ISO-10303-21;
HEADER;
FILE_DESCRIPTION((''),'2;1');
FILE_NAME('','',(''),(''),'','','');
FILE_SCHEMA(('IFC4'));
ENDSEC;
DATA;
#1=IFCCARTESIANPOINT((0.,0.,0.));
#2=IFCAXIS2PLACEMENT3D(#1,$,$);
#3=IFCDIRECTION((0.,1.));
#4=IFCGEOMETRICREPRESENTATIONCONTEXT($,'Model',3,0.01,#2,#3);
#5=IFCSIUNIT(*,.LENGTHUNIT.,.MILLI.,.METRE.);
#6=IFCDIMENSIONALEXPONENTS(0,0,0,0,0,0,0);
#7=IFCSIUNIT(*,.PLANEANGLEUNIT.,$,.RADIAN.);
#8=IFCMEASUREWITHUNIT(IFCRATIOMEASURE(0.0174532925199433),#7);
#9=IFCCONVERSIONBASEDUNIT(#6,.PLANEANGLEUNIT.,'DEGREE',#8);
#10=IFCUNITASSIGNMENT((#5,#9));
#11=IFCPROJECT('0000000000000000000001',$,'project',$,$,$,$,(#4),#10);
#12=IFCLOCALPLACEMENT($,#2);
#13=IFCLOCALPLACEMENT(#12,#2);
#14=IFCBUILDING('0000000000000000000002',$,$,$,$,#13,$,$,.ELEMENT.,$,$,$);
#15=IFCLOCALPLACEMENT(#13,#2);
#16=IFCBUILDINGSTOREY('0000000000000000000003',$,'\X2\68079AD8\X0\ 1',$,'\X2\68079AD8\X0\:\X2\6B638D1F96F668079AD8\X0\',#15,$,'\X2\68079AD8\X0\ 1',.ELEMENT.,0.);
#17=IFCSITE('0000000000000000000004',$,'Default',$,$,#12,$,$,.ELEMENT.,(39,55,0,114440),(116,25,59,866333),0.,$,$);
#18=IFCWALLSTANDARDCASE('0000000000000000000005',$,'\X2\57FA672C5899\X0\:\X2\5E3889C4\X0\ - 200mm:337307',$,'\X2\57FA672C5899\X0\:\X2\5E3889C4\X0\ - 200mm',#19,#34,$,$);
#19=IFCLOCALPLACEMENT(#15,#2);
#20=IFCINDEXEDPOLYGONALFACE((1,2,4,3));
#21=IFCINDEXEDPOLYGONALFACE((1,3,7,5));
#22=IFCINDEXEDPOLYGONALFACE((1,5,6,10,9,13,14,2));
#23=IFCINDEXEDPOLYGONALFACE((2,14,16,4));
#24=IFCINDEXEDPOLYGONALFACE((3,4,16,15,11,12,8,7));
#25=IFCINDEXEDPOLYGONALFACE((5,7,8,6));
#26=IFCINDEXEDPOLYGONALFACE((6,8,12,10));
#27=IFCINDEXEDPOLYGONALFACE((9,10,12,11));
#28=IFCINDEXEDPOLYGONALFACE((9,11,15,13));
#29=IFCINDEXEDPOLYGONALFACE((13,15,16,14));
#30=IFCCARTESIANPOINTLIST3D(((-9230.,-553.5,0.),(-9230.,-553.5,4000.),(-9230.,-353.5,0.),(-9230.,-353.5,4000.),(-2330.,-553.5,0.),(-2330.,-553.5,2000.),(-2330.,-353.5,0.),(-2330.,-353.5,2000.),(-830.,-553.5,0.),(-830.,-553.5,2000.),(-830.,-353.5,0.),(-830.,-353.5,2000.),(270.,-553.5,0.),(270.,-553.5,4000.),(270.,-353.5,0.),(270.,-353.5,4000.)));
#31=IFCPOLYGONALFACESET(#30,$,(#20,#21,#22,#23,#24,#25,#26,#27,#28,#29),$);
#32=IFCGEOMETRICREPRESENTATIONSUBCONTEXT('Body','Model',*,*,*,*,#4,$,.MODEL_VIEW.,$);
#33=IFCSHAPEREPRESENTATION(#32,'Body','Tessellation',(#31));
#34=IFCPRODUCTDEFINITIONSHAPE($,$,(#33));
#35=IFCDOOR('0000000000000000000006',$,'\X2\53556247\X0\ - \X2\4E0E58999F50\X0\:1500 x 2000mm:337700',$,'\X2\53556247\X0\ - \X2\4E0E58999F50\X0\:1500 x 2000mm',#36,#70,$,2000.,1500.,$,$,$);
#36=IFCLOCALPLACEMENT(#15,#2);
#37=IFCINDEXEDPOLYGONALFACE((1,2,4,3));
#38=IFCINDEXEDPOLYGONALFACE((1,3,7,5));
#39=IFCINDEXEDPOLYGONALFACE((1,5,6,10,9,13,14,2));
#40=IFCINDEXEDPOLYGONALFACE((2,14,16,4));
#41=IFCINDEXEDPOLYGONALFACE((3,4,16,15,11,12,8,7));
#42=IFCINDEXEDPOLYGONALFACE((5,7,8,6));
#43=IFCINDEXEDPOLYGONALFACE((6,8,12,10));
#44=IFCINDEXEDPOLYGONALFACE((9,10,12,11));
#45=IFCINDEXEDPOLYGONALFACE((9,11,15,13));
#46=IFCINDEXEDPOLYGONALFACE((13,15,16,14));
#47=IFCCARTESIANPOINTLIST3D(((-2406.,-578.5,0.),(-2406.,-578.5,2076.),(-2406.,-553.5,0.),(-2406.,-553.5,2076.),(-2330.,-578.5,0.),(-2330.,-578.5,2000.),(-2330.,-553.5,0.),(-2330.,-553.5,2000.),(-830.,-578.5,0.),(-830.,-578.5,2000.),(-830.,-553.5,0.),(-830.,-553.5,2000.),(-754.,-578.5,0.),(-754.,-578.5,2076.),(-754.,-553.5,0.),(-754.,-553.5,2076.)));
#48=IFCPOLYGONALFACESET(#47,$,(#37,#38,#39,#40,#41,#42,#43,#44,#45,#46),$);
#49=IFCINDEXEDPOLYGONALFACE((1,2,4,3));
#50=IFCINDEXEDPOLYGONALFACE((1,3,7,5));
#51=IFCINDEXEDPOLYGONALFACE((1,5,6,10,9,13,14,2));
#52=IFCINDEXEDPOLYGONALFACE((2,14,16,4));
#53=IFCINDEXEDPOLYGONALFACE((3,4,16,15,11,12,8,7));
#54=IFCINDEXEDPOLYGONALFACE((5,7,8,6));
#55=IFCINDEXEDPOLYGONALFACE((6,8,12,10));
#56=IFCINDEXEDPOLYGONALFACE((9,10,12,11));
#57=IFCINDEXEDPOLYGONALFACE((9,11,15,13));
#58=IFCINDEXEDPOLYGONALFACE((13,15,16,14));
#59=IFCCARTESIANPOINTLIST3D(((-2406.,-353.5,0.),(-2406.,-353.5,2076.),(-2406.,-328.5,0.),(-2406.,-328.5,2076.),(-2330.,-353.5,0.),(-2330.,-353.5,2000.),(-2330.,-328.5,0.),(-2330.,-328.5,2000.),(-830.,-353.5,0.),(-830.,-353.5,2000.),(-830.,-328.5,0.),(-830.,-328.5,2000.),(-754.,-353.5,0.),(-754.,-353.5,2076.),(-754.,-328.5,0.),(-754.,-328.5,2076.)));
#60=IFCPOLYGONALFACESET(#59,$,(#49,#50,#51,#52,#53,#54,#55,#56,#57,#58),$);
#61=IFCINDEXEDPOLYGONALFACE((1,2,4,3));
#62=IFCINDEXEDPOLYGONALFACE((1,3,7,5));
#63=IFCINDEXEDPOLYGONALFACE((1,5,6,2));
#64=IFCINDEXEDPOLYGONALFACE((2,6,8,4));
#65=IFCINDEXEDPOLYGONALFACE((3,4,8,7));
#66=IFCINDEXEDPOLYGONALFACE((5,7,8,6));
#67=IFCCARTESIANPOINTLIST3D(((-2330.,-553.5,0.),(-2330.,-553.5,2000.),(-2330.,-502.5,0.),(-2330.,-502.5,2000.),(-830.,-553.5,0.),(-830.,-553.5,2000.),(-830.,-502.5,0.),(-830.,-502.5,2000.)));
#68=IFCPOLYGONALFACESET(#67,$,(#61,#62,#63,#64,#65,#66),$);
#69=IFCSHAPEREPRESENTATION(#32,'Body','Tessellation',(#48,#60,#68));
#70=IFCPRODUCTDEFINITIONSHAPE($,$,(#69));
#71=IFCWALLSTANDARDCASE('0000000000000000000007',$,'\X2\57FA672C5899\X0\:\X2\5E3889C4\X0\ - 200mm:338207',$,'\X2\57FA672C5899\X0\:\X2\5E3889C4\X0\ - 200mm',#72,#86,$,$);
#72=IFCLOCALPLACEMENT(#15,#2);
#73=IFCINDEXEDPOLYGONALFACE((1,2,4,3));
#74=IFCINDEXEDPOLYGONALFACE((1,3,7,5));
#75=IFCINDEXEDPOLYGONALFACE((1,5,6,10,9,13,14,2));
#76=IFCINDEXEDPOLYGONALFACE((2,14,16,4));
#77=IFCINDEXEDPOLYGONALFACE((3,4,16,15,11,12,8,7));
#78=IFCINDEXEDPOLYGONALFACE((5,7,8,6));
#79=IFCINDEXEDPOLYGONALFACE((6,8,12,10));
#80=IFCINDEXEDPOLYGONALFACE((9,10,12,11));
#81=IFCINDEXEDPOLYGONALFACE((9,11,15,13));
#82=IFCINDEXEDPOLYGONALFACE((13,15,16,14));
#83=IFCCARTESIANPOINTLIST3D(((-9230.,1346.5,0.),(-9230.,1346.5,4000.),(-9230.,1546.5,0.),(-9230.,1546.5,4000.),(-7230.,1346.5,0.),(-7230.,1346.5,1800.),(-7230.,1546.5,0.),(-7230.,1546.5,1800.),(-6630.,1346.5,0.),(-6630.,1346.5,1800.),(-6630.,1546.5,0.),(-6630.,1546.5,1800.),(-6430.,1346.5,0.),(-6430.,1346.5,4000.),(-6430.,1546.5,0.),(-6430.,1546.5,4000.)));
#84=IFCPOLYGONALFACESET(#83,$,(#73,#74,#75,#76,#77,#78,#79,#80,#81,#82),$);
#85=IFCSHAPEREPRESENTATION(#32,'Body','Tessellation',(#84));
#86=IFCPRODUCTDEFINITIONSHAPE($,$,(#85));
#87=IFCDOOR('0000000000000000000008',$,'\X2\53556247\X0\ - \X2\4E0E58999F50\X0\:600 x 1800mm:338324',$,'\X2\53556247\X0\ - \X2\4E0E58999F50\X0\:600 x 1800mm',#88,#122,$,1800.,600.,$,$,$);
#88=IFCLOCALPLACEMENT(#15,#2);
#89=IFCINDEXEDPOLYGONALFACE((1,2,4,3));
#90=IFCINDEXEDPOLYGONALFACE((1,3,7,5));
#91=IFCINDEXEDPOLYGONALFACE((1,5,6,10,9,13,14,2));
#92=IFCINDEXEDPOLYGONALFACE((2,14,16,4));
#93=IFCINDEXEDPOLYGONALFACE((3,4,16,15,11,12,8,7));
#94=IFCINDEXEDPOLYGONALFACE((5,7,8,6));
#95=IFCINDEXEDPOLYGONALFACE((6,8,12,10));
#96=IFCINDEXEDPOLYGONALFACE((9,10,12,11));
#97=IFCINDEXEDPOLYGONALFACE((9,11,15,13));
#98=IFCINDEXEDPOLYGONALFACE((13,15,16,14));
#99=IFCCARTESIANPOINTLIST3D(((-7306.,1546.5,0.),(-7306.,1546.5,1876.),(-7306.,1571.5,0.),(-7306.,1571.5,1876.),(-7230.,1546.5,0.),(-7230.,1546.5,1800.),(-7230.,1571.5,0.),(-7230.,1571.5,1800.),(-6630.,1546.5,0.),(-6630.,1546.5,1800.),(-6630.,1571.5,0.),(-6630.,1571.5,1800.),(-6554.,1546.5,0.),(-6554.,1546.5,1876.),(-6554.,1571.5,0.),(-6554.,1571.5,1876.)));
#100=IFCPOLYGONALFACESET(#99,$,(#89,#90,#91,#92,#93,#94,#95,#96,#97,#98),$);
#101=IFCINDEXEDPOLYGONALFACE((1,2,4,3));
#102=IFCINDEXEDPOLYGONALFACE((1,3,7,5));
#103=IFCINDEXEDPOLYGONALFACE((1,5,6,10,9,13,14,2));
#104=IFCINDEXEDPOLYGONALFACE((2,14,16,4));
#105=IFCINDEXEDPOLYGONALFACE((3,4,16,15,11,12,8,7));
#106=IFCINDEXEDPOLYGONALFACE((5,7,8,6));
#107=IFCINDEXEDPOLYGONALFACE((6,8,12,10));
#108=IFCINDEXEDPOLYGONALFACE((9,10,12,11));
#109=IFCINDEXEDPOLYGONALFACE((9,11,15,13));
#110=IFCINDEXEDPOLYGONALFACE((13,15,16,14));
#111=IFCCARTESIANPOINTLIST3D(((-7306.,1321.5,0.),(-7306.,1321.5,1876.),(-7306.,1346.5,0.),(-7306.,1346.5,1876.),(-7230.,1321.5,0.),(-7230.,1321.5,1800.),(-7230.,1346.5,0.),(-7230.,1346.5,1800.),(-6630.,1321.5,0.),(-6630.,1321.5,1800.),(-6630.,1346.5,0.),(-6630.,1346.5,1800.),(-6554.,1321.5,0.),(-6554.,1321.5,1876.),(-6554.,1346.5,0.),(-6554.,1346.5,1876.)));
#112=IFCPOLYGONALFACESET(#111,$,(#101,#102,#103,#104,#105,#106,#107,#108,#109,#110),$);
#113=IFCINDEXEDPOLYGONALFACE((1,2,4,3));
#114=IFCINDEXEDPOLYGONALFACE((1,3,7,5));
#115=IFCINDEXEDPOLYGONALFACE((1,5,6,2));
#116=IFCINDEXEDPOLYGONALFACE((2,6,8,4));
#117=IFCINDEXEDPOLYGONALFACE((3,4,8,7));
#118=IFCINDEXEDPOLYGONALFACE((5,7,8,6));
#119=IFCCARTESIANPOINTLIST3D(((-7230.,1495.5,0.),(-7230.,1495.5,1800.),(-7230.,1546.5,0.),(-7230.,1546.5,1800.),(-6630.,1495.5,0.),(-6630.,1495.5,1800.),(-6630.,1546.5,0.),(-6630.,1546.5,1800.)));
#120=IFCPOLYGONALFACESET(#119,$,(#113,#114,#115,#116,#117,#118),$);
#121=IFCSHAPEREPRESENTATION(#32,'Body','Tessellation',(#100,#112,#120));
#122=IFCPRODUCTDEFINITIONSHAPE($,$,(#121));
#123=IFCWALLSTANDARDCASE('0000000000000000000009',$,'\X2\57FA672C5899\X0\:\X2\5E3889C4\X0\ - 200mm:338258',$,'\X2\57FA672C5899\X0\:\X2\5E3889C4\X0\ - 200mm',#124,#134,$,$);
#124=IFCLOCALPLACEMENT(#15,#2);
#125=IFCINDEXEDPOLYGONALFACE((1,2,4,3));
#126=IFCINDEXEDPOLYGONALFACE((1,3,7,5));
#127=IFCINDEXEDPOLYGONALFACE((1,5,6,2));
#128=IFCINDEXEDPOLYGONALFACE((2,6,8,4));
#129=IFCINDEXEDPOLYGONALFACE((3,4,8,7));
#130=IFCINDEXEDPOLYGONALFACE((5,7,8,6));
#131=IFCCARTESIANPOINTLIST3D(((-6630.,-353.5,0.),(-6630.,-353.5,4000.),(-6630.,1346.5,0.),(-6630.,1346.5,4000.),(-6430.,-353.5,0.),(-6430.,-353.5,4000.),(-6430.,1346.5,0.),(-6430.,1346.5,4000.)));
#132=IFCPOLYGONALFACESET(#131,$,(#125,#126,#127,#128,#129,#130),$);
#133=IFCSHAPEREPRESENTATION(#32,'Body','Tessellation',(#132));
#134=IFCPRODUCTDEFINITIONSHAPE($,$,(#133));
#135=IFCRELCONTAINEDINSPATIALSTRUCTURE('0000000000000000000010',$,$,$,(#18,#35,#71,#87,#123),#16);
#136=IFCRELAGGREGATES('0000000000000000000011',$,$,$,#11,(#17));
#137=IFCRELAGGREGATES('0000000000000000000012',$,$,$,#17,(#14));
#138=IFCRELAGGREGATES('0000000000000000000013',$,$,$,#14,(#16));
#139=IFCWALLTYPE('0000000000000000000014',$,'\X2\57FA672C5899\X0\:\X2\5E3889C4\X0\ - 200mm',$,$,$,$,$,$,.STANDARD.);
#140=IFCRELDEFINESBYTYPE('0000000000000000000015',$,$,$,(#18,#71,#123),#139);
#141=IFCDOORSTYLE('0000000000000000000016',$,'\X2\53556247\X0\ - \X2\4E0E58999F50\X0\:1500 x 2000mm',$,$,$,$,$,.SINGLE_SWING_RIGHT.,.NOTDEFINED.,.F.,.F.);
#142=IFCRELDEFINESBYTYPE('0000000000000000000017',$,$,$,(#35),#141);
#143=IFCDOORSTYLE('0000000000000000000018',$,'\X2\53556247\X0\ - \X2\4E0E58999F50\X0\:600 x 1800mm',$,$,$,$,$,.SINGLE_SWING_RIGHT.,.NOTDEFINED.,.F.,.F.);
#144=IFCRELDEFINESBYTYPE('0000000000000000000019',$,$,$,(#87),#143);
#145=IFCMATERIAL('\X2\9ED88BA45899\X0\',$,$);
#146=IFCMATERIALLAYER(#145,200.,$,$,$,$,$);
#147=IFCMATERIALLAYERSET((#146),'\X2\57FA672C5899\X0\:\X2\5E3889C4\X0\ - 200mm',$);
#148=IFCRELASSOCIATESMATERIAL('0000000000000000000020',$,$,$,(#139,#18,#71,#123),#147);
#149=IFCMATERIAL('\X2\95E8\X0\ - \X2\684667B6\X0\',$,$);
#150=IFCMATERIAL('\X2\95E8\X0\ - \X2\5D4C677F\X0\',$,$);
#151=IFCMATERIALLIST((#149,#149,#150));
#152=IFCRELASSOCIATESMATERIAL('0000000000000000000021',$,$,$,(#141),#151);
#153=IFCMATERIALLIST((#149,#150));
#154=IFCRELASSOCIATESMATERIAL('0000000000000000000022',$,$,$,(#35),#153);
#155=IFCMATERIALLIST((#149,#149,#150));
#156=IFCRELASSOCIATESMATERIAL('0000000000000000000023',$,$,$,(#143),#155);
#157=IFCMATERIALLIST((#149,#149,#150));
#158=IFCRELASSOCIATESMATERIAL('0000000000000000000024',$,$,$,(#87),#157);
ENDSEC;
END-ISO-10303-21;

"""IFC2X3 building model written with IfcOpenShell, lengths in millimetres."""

from ifc_helpers import new_model, entity, si_unit, converted_unit, direction, frame, frame_2d, origin, place, context, subcontext, project, spatial, polyline, rectangle, outline, extrude, source, transform, mapped, material, material_list, layer, layer_set, layer_usage, type_object, type_shapes, element, fill, save


model = new_model("IFC2X3")

# Units and contexts
model_context = context("Model", 3, precision=0.01, world=origin(), true_north=direction((0.0, 1.0)))
body_context = subcontext(model_context, "Body", "Model", "MODEL_VIEW")
ifc_project = project(units=[si_unit("LENGTHUNIT", "METRE", prefix="MILLI"), converted_unit("PLANEANGLEUNIT", "DEGREE", entity("IfcRatioMeasure", 0.0174532925199433), si_unit("PLANEANGLEUNIT", "RADIAN"), dimensions=[0, 0, 0, 0, 0, 0, 0])], contexts=[model_context])

# Site, building, storey
site_placement = place(None, origin())
site = spatial("IfcSite", under=ifc_project, at=site_placement, Name="Default", CompositionType="ELEMENT", RefLatitude=(39, 55, 0, 114440), RefLongitude=(116, 25, 59, 866333), RefElevation=0.0)
building_placement = place(site_placement, origin())
building = spatial("IfcBuilding", under=site, at=building_placement, CompositionType="ELEMENT")
storey_placement = place(building_placement, origin())
storey = spatial("IfcBuildingStorey", under=building, at=storey_placement, Name="标高 1", ObjectType="标高:正负零标高", LongName="标高 1", CompositionType="ELEMENT", Elevation=0.0)

# Shared definitions
ifc_material_1 = material(Name="默认墙")
ifc_layer = layer(ifc_material_1, 200.0)
ifc_layer_set = layer_set([ifc_layer], Name="基本墙:常规 - 200mm")
wall_type = type_object("IfcWallType", Name="基本墙:常规 - 200mm", PredefinedType="STANDARD", material=ifc_layer_set)

# Shared definitions
ifc_material_2 = material(Name="门 - 框架")
ifc_material_3 = material(Name="门 - 嵌板")
ifc_material_list_1 = material_list([ifc_material_2, ifc_material_2, ifc_material_3])
door_style_1 = type_object("IfcDoorStyle", Name="单扇 - 与墙齐:1500 x 2000mm", ConstructionType="NOTDEFINED", OperationType="SINGLE_SWING_RIGHT", ParameterTakesPrecedence=False, Sizeable=False, material=ifc_material_list_1)
shared_shape_1 = source(origin(), body_context, "Body", "SweptSolid", [
    extrude(outline(polyline([(-826.0, -1057.0), (826.0, -1057.0), (826.0, 1019.0), (750.0, 1019.0), (750.0, -981.0), (-750.0, -981.0), (-750.0, 1019.0), (-826.0, 1019.0), (-826.0, -1057.0)])), frame((750.0, 200.0, 1019.0), z_axis=(0.0, 1.0, 0.0), x_axis=(1.0, 0.0, 0.0)), (0.0, 0.0, 1.0), 25.0),
    extrude(outline(polyline([(-1057.0, -826.0), (1019.0, -826.0), (1019.0, -750.0), (-981.0, -750.0), (-981.0, 750.0), (1019.0, 750.0), (1019.0, 826.0), (-1057.0, 826.0), (-1057.0, -826.0)])), frame((750.0, -25.0, 1019.0), z_axis=(0.0, 1.0, 0.0), x_axis=(0.0, 0.0, -1.0)), (0.0, 0.0, 1.0), 25.0),
    extrude(rectangle(XDim=51.0, YDim=1500.0, at=frame_2d((0.0, 0.0), x_axis=(1.0, 0.0))), frame((750.0, 174.5, 0.0), z_axis=(0.0, 0.0, 1.0), x_axis=(0.0, 1.0, 0.0)), (0.0, 0.0, 1.0), 2000.0),
])
type_shapes(door_style_1, [shared_shape_1])

# Walls, openings, doors
ifc_layer_usage_1 = layer_usage(ifc_layer_set, "AXIS2", "NEGATIVE", 100.0)
wall_1_placement = place(storey_placement, frame((-9230.0, -453.5, 0.0)))
wall_1 = element("IfcWallStandardCase", 1, at=wall_1_placement, inside=storey, type_object=wall_type, material=ifc_layer_usage_1, Name="基本墙:常规 - 200mm:337307", ObjectType="基本墙:常规 - 200mm", context=body_context, shape_type="SweptSolid", body=[
    extrude(rectangle(XDim=9500.0, YDim=200.0, at=frame_2d((4750.0, 0.0), x_axis=(-1.0, 0.0))), origin(), (0.0, 0.0, 1.0), 4000.0),
])
opening_1_placement = place(wall_1_placement, frame((8400.0, 100.0, 0.0)))
opening_1 = element("IfcOpeningElement", 2, at=opening_1_placement, cuts=wall_1, ObjectType="Opening", context=body_context, shape_type="SweptSolid", body=[
    extrude(rectangle(XDim=1500.0, YDim=2000.0, at=frame_2d((1000.0, 750.0), x_axis=(0.0, 1.0))), frame((0.0, 0.0, 0.0), z_axis=(0.0, -1.0, 0.0), x_axis=(0.0, 0.0, 1.0)), (0.0, 0.0, 1.0), 200.0),
])
ifc_material_list_2 = material_list([ifc_material_2, ifc_material_3])
door_1_placement = place(opening_1_placement, frame((0.0, 0.0, 0.0), z_axis=(0.0, 0.0, 1.0), x_axis=(-1.0, 0.0, 0.0)))
door_1 = element("IfcDoor", 3, at=door_1_placement, inside=storey, type_object=door_style_1, material=ifc_material_list_2, Name="单扇 - 与墙齐:1500 x 2000mm:337700", ObjectType="单扇 - 与墙齐:1500 x 2000mm", OverallHeight=2000.0, OverallWidth=1500.0, context=body_context, shape_type="MappedRepresentation", body=[
    mapped(shared_shape_1, transform((0.0, 0.0, 0.0), scale=1.0)),
])
fill(opening_1, door_1)
ifc_layer_usage_2 = layer_usage(ifc_layer_set, "AXIS2", "NEGATIVE", 100.0)
wall_2_placement = place(storey_placement, frame((-9230.0, 1446.5, 0.0)))
wall_2 = element("IfcWallStandardCase", 4, at=wall_2_placement, inside=storey, type_object=wall_type, material=ifc_layer_usage_2, Name="基本墙:常规 - 200mm:338207", ObjectType="基本墙:常规 - 200mm", context=body_context, shape_type="SweptSolid", body=[
    extrude(rectangle(XDim=2800.0, YDim=200.0, at=frame_2d((1400.0, 0.0), x_axis=(-1.0, 0.0))), origin(), (0.0, 0.0, 1.0), 4000.0),
])
opening_2_placement = place(wall_2_placement, frame((2000.0, -100.0, 0.0)))
opening_2 = element("IfcOpeningElement", 5, at=opening_2_placement, cuts=wall_2, ObjectType="Opening", context=body_context, shape_type="SweptSolid", body=[
    extrude(rectangle(XDim=600.0, YDim=1800.0, at=frame_2d((900.0, 300.0), x_axis=(0.0, 1.0))), frame((0.0, 0.0, 0.0), z_axis=(0.0, 1.0, 0.0), x_axis=(0.0, 0.0, 1.0)), (0.0, 0.0, 1.0), 200.0),
])
ifc_material_list_3 = material_list([ifc_material_2, ifc_material_2, ifc_material_3])
ifc_material_list_4 = material_list([ifc_material_2, ifc_material_2, ifc_material_3])
door_style_2 = type_object("IfcDoorStyle", Name="单扇 - 与墙齐:600 x 1800mm", ConstructionType="NOTDEFINED", OperationType="SINGLE_SWING_RIGHT", ParameterTakesPrecedence=False, Sizeable=False, material=ifc_material_list_4)
shared_shape_2 = source(origin(), body_context, "Body", "SweptSolid", [
    extrude(outline(polyline([(-376.0, -957.0), (376.0, -957.0), (376.0, 919.0), (300.0, 919.0), (300.0, -881.0), (-300.0, -881.0), (-300.0, 919.0), (-376.0, 919.0), (-376.0, -957.0)])), frame((300.0, 200.0, 919.0), z_axis=(0.0, 1.0, 0.0), x_axis=(1.0, 0.0, 0.0)), (0.0, 0.0, 1.0), 25.0),
    extrude(outline(polyline([(-957.0, -376.0), (919.0, -376.0), (919.0, -300.0), (-881.0, -300.0), (-881.0, 300.0), (919.0, 300.0), (919.0, 376.0), (-957.0, 376.0), (-957.0, -376.0)])), frame((300.0, -25.0, 919.0), z_axis=(0.0, 1.0, 0.0), x_axis=(0.0, 0.0, -1.0)), (0.0, 0.0, 1.0), 25.0),
    extrude(rectangle(XDim=51.0, YDim=600.0, at=frame_2d((0.0, 0.0), x_axis=(1.0, 0.0))), frame((300.0, 174.5, 0.0), z_axis=(0.0, 0.0, 1.0), x_axis=(0.0, 1.0, 0.0)), (0.0, 0.0, 1.0), 1800.0),
])
type_shapes(door_style_2, [shared_shape_2])
door_2_placement = place(opening_2_placement, origin())
door_2 = element("IfcDoor", 6, at=door_2_placement, inside=storey, type_object=door_style_2, material=ifc_material_list_3, Name="单扇 - 与墙齐:600 x 1800mm:338324", ObjectType="单扇 - 与墙齐:600 x 1800mm", OverallHeight=1800.0, OverallWidth=600.0, context=body_context, shape_type="MappedRepresentation", body=[
    mapped(shared_shape_2, transform((0.0, 0.0, 0.0), scale=1.0)),
])
fill(opening_2, door_2)

# Wall
ifc_layer_usage_3 = layer_usage(ifc_layer_set, "AXIS2", "NEGATIVE", 100.0)
wall_3_placement = place(storey_placement, frame((-6530.0, 1346.5, 0.0), z_axis=(0.0, 0.0, 1.0), x_axis=(0.0, -1.0, 0.0)))
element("IfcWallStandardCase", 7, at=wall_3_placement, inside=storey, type_object=wall_type, material=ifc_layer_usage_3, Name="基本墙:常规 - 200mm:338258", ObjectType="基本墙:常规 - 200mm", context=body_context, shape_type="SweptSolid", body=[
    extrude(rectangle(XDim=1700.0, YDim=200.0, at=frame_2d((850.0, 0.0), x_axis=(-1.0, 0.0))), origin(), (0.0, 0.0, 1.0), 4000.0),
])

save(model, "model.ifc")
